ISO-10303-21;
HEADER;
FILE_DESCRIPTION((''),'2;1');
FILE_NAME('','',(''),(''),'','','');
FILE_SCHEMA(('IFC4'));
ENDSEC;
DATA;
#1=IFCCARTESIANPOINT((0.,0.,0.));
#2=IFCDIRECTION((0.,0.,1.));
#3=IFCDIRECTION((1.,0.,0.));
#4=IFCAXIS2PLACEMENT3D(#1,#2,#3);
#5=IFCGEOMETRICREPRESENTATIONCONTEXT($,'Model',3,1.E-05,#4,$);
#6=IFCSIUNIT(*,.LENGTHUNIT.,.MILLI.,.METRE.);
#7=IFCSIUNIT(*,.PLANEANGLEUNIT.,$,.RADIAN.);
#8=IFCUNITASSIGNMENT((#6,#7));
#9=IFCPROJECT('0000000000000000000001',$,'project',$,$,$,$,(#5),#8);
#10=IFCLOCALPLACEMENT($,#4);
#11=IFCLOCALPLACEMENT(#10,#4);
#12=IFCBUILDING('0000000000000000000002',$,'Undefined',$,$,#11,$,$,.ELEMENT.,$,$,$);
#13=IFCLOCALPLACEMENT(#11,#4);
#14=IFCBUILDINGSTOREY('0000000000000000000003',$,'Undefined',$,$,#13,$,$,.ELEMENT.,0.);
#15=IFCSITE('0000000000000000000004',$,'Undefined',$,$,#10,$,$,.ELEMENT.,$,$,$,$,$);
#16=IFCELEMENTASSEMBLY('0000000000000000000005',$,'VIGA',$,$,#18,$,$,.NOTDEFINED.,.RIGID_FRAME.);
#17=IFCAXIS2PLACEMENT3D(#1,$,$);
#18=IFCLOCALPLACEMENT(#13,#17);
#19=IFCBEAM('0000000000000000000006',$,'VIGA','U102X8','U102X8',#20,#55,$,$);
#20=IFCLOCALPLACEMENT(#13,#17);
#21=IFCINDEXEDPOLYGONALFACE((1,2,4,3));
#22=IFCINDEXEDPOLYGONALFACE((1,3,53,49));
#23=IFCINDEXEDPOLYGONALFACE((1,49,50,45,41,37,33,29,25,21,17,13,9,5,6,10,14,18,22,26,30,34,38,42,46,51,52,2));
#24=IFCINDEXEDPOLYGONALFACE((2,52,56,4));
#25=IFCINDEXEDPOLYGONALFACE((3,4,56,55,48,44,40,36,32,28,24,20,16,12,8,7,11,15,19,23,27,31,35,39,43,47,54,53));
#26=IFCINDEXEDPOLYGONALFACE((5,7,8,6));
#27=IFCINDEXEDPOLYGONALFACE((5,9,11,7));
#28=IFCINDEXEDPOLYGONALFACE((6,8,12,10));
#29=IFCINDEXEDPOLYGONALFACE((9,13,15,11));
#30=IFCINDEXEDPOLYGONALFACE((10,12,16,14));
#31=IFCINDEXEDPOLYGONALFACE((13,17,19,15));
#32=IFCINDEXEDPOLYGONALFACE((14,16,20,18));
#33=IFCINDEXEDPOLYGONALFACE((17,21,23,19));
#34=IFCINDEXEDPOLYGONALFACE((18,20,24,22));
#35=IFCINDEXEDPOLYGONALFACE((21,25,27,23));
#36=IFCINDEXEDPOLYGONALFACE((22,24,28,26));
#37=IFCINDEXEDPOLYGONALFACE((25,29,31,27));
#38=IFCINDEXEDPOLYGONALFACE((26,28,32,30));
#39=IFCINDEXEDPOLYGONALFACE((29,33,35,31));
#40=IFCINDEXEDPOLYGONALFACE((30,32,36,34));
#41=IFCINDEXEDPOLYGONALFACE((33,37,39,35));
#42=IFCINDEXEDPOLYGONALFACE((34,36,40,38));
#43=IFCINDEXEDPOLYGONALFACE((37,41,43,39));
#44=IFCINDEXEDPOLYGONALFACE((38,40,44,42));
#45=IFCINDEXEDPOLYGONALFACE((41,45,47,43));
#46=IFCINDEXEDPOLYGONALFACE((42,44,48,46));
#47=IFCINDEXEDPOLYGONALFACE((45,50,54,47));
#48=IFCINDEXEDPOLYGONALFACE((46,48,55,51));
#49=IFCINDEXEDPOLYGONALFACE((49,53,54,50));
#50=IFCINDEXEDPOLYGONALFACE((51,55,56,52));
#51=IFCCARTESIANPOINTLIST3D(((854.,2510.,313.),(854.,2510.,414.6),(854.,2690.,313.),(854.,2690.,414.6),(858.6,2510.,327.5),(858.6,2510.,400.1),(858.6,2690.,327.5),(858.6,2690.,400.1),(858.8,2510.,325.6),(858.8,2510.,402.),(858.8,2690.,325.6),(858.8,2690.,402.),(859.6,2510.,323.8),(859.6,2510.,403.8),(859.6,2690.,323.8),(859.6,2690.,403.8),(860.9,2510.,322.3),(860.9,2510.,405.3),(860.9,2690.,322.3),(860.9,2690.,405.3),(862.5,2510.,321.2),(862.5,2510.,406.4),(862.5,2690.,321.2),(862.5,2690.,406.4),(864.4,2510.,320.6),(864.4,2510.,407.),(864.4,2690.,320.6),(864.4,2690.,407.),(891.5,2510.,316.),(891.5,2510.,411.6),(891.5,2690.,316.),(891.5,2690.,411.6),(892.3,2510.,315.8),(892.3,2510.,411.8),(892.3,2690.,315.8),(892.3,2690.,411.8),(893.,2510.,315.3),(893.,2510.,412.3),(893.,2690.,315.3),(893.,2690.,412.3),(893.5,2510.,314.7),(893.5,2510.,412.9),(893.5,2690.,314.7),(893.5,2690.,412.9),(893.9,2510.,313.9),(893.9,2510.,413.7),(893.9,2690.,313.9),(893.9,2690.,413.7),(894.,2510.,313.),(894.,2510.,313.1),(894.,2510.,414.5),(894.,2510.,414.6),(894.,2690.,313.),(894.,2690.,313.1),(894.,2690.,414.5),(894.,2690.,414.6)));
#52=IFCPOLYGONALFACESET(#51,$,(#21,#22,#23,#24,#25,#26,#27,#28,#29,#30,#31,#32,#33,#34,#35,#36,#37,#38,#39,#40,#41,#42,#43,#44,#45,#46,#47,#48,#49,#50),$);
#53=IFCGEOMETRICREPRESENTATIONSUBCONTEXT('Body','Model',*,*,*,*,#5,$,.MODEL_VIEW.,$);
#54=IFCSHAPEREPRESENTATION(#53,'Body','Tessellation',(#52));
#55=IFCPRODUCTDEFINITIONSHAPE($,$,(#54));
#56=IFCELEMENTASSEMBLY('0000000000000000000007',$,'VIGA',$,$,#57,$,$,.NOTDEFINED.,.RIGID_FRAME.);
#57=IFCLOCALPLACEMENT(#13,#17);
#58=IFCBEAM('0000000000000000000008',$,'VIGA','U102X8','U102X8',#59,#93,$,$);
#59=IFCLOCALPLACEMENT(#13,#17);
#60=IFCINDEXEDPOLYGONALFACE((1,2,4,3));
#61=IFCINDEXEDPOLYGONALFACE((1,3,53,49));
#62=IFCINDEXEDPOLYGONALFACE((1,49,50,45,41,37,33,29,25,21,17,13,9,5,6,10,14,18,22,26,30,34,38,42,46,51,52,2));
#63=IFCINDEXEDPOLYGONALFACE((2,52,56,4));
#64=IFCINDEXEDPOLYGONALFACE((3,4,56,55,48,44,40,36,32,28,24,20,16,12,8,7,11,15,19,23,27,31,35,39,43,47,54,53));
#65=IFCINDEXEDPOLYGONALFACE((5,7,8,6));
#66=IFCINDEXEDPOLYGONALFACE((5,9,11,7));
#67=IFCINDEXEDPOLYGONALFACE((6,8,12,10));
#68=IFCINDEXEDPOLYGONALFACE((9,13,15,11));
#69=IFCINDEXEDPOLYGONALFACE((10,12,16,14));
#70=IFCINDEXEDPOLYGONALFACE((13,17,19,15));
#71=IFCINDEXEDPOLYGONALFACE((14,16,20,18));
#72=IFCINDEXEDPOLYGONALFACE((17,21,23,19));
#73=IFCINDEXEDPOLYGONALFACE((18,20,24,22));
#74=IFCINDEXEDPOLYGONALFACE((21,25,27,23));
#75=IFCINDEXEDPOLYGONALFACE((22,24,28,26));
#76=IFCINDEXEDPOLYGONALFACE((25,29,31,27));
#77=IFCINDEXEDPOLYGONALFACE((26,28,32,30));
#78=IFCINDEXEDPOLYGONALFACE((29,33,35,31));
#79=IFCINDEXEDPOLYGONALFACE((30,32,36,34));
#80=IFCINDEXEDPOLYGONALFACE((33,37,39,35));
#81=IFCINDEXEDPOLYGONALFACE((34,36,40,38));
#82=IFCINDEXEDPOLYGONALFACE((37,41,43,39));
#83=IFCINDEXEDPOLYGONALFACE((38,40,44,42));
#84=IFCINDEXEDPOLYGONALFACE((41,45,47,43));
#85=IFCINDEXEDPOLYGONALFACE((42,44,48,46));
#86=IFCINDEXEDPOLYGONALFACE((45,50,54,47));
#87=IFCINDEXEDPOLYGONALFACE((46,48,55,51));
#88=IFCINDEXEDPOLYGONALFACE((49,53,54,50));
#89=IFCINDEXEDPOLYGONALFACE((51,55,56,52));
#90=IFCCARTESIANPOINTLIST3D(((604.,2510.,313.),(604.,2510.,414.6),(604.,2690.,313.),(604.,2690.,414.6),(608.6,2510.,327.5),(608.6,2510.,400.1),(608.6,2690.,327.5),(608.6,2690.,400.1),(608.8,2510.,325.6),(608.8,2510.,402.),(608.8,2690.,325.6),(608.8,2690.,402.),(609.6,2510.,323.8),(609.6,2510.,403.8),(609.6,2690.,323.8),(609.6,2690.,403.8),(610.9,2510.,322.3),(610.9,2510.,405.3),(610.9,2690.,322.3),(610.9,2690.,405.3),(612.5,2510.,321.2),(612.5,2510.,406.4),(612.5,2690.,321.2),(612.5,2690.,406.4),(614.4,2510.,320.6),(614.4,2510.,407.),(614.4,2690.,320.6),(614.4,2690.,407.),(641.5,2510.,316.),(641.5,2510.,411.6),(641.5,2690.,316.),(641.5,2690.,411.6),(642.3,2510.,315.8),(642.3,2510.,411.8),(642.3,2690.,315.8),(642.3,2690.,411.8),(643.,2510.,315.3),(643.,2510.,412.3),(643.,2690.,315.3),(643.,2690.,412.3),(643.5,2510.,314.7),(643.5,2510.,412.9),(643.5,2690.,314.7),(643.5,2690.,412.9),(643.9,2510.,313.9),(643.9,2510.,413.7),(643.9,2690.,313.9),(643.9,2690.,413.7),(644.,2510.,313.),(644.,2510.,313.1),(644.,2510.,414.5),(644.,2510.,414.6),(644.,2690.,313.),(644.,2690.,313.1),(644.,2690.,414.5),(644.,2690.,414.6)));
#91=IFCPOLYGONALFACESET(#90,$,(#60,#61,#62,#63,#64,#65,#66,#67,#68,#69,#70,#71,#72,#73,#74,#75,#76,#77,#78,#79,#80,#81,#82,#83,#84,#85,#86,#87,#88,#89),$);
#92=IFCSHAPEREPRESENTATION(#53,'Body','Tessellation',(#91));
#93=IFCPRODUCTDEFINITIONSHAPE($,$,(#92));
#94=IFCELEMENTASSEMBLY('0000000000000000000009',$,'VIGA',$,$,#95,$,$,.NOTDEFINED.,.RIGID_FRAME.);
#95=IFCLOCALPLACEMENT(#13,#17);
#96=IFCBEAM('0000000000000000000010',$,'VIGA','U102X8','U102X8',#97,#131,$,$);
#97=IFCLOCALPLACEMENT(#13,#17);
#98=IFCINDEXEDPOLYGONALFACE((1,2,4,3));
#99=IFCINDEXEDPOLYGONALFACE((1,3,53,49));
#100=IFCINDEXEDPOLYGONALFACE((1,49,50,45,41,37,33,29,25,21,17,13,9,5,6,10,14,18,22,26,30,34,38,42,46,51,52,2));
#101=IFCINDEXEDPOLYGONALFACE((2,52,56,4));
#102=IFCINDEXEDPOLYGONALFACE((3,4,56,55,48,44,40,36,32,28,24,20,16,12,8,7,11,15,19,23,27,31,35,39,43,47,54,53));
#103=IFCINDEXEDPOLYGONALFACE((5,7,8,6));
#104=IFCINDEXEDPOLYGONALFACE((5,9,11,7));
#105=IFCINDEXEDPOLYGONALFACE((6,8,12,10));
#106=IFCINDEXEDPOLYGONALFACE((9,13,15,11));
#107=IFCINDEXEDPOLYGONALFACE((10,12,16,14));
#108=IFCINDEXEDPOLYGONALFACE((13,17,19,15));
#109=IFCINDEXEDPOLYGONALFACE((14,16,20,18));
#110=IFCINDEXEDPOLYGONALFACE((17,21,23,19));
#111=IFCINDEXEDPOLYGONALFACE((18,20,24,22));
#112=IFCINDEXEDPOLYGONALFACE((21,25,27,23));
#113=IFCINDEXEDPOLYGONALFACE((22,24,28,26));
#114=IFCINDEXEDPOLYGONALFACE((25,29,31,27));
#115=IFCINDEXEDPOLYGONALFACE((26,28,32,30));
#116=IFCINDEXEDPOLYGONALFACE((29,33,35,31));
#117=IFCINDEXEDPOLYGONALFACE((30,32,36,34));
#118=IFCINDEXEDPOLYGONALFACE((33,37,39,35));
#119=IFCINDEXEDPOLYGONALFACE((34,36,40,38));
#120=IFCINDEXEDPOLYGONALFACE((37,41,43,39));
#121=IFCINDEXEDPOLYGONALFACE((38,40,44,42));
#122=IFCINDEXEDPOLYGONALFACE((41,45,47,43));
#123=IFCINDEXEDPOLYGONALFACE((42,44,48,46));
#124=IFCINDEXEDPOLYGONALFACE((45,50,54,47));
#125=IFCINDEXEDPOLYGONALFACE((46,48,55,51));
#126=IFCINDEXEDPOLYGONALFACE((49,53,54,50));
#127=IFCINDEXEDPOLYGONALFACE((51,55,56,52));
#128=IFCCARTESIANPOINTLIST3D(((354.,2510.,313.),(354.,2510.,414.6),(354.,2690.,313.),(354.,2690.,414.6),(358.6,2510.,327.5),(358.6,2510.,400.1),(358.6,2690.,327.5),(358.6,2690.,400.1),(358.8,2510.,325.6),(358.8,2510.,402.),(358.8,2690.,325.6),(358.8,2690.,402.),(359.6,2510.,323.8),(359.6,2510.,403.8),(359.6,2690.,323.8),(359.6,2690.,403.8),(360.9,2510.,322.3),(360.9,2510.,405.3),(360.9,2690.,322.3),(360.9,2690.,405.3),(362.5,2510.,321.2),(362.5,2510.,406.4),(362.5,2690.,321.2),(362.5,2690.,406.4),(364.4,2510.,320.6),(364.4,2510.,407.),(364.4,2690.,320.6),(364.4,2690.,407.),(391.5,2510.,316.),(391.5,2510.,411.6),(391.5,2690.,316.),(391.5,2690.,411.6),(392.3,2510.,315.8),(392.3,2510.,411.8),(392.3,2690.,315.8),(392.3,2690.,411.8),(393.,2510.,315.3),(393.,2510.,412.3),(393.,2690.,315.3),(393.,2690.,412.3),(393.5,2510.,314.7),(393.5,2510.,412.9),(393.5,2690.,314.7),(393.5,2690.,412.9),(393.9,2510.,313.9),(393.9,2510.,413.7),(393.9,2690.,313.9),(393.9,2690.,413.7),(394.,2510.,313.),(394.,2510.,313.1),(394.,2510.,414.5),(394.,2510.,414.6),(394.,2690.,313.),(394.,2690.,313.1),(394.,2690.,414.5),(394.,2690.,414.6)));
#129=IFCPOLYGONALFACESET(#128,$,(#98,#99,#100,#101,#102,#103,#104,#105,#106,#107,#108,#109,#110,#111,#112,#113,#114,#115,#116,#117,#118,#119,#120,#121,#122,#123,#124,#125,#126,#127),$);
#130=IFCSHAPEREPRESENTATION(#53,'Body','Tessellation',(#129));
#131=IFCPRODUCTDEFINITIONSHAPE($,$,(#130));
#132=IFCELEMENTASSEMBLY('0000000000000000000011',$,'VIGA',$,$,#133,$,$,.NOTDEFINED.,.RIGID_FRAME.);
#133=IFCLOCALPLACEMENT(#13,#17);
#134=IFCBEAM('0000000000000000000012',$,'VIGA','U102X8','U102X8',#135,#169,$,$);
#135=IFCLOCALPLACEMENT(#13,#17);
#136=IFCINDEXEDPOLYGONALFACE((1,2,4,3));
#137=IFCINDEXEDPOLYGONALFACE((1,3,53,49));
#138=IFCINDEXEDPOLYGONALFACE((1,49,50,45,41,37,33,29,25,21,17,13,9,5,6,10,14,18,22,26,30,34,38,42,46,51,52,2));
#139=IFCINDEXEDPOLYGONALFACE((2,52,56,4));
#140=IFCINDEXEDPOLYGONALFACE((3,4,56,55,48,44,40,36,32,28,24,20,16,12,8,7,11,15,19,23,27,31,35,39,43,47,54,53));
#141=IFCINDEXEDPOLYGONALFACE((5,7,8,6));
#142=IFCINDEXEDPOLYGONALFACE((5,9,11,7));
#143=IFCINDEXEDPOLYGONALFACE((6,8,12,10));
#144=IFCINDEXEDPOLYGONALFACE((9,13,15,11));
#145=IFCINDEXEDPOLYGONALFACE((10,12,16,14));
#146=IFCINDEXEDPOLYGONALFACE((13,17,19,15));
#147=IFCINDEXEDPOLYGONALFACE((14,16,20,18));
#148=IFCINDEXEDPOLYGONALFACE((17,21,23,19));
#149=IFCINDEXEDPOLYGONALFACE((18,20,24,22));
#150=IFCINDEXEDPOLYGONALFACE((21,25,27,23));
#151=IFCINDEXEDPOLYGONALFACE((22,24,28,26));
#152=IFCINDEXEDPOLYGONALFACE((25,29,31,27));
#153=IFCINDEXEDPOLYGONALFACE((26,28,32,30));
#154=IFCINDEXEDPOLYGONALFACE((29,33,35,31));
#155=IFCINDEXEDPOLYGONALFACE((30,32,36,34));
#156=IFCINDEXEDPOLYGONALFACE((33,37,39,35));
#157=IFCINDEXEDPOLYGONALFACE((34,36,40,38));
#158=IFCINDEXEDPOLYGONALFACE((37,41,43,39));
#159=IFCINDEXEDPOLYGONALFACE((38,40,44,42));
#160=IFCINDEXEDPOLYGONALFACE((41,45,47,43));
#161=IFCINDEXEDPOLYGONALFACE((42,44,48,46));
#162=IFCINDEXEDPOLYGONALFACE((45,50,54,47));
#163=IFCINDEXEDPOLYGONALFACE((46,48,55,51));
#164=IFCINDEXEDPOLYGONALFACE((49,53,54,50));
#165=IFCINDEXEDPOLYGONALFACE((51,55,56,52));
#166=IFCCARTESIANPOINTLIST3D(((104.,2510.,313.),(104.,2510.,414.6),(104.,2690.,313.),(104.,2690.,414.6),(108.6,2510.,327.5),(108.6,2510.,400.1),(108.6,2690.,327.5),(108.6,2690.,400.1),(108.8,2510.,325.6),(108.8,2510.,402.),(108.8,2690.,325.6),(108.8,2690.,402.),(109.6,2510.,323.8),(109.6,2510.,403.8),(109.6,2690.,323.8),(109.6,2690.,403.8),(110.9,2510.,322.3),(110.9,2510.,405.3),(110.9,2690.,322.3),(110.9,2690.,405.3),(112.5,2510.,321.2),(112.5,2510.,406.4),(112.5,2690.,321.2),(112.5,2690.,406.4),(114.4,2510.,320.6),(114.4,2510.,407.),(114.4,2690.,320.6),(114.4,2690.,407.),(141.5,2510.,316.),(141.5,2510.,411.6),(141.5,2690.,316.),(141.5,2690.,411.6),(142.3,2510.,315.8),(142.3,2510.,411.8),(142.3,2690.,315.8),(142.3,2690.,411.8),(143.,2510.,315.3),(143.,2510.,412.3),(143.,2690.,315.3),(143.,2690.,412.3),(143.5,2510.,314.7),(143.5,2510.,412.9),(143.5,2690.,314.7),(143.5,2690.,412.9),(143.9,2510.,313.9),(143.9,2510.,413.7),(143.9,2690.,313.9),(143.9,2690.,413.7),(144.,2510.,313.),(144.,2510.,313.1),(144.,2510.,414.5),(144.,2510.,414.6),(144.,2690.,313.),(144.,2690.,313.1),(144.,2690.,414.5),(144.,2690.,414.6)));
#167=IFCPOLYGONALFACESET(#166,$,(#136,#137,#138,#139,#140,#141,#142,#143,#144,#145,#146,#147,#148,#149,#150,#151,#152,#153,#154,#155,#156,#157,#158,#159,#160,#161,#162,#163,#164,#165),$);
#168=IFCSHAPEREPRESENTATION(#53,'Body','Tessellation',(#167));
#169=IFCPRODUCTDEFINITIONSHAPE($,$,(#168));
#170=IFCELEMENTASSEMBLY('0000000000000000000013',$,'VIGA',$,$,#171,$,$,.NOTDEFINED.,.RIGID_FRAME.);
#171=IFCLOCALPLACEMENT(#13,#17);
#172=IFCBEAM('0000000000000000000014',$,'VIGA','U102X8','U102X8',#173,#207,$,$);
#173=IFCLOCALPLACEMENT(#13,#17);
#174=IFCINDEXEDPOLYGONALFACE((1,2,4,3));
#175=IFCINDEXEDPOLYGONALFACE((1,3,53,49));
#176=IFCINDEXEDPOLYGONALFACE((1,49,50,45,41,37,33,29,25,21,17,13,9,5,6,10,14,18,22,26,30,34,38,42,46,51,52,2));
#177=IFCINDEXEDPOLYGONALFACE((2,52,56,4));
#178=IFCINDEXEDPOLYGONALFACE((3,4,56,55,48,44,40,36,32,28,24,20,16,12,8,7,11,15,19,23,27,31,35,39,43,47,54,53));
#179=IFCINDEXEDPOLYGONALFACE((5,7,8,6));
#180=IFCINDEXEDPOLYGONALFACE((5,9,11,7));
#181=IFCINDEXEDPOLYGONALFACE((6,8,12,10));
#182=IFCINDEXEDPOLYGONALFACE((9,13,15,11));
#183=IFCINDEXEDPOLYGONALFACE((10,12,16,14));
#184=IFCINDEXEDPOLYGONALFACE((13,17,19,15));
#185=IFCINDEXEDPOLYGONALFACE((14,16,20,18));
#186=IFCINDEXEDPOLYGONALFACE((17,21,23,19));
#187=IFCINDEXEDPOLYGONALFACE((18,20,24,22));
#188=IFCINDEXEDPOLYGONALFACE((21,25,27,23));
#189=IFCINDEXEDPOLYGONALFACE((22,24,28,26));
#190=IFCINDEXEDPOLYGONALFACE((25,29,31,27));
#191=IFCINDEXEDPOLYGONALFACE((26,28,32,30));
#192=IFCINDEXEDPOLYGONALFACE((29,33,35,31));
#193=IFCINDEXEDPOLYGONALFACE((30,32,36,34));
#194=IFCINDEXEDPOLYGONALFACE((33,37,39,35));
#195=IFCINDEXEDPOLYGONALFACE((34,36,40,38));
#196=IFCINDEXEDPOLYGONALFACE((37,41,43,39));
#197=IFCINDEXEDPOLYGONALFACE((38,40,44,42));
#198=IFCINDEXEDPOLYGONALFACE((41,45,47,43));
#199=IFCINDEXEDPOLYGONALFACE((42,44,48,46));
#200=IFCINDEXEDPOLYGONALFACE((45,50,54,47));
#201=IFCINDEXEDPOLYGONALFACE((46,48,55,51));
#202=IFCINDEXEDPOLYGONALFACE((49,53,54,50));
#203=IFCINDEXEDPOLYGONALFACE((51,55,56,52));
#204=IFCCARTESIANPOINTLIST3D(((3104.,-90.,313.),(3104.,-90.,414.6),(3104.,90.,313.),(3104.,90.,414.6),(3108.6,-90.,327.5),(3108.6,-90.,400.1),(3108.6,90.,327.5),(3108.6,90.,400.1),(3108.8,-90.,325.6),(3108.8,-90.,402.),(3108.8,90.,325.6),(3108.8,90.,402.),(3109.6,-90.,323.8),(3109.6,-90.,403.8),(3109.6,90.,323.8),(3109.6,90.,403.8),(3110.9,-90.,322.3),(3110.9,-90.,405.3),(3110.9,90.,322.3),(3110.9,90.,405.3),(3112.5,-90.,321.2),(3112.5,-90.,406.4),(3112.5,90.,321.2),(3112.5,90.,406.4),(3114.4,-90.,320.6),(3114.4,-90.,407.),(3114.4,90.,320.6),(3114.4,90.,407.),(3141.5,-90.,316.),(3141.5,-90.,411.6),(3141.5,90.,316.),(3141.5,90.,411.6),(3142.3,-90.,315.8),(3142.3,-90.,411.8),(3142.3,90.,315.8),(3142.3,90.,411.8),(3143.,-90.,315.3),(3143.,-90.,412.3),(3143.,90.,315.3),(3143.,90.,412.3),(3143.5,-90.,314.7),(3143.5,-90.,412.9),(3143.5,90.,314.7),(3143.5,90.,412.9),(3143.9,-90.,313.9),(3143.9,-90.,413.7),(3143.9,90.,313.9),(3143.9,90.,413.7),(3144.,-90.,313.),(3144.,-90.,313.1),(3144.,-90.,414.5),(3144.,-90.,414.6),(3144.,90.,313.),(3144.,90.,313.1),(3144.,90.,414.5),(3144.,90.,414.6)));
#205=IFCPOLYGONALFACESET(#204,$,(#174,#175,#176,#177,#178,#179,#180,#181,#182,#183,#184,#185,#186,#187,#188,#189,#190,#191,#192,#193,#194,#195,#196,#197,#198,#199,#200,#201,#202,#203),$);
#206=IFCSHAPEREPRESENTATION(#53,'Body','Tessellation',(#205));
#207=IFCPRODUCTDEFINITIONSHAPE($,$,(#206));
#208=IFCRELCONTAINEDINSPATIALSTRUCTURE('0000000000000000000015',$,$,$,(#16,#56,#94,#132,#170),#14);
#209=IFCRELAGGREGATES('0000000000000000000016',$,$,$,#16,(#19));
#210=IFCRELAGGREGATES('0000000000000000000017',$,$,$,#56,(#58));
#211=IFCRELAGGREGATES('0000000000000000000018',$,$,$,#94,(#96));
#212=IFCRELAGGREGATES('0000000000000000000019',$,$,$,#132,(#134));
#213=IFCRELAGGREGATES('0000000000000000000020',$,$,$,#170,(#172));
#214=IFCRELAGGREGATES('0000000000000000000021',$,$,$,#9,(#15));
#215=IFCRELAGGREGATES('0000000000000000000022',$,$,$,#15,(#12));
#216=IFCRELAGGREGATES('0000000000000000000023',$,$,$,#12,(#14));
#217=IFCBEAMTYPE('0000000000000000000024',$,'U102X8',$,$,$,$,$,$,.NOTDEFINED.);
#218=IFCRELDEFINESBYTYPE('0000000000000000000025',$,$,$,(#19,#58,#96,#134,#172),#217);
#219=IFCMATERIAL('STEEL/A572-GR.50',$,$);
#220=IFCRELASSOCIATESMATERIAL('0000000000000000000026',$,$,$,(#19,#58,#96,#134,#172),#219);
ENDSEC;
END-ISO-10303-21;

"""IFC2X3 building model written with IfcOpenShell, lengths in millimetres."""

from ifc_helpers import new_model, si_unit, frame, origin_with_axes, origin_2d_with_axis, place, context, subcontext, project, spatial, u_section, extrude, material, type_object, element, aggregate, save


model = new_model("IFC2X3")

# Units and contexts
model_context = context("Model", 3, precision=1e-05, world=origin_with_axes())
body_context = subcontext(model_context, "Body", "Model", "MODEL_VIEW")
ifc_project = project(units=[si_unit("LENGTHUNIT", "METRE", prefix="MILLI"), si_unit("PLANEANGLEUNIT", "RADIAN")], contexts=[model_context])

# Site, building, storey
site_placement = place(None, origin_with_axes())
site = spatial("IfcSite", under=ifc_project, at=site_placement, Name="Undefined", CompositionType="ELEMENT")
building_placement = place(site_placement, origin_with_axes())
building = spatial("IfcBuilding", under=site, at=building_placement, Name="Undefined", CompositionType="ELEMENT")
storey_placement = place(building_placement, origin_with_axes())
storey = spatial("IfcBuildingStorey", under=building, at=storey_placement, Name="Undefined", CompositionType="ELEMENT", Elevation=0.0)

# Element assemblies, beams
ifc_material_1 = material(Name="STEEL/A572-GR.50")
beam_type_1 = type_object("IfcBeamType", Name="U102X8", PredefinedType="NOTDEFINED")
assembly_1_placement = place(storey_placement, origin_with_axes())
assembly_1 = element("IfcElementAssembly", 1, at=assembly_1_placement, inside=storey, Name="VIGA", AssemblyPlace="NOTDEFINED", PredefinedType="RIGID_FRAME")
beam_1_placement = place(assembly_1_placement, frame((874.0, 2510.0, 363.8), z_axis=(0.0, 0.0, 1.0), x_axis=(0.0, 1.0, 0.0)))
beam_1 = element("IfcBeam", 2, at=beam_1_placement, type_object=beam_type_1, material=ifc_material_1, Name="VIGA", Description="U102X8", ObjectType="U102X8", context=body_context, shape_type="SweptSolid", body=[
    extrude(u_section(Depth=101.6, FlangeWidth=40.0, WebThickness=4.6, FlangeThickness=6.0, FilletRadius=7.0, EdgeRadius=3.0, FlangeSlope=0.16839, at=origin_2d_with_axis()), frame((180.0, 0.0, 0.0), z_axis=(-1.0, 0.0, 0.0), x_axis=(0.0, -1.0, 0.0)), (0.0, 0.0, 1.0), 180.0),
])
aggregate(assembly_1, [beam_1])
assembly_2_placement = place(storey_placement, origin_with_axes())
assembly_2 = element("IfcElementAssembly", 3, at=assembly_2_placement, inside=storey, Name="VIGA", AssemblyPlace="NOTDEFINED", PredefinedType="RIGID_FRAME")
beam_2_placement = place(assembly_2_placement, frame((624.0, 2510.0, 363.8), z_axis=(0.0, 0.0, 1.0), x_axis=(0.0, 1.0, 0.0)))
beam_2 = element("IfcBeam", 4, at=beam_2_placement, type_object=beam_type_1, material=ifc_material_1, Name="VIGA", Description="U102X8", ObjectType="U102X8", context=body_context, shape_type="SweptSolid", body=[
    extrude(u_section(Depth=101.6, FlangeWidth=40.0, WebThickness=4.6, FlangeThickness=6.0, FilletRadius=7.0, EdgeRadius=3.0, FlangeSlope=0.16839, at=origin_2d_with_axis()), frame((180.0, 0.0, 0.0), z_axis=(-1.0, 0.0, 0.0), x_axis=(0.0, -1.0, 0.0)), (0.0, 0.0, 1.0), 180.0),
])
aggregate(assembly_2, [beam_2])
assembly_3_placement = place(storey_placement, origin_with_axes())
assembly_3 = element("IfcElementAssembly", 5, at=assembly_3_placement, inside=storey, Name="VIGA", AssemblyPlace="NOTDEFINED", PredefinedType="RIGID_FRAME")
beam_3_placement = place(assembly_3_placement, frame((374.0, 2510.0, 363.8), z_axis=(0.0, 0.0, 1.0), x_axis=(0.0, 1.0, 0.0)))
beam_3 = element("IfcBeam", 6, at=beam_3_placement, type_object=beam_type_1, material=ifc_material_1, Name="VIGA", Description="U102X8", ObjectType="U102X8", context=body_context, shape_type="SweptSolid", body=[
    extrude(u_section(Depth=101.6, FlangeWidth=40.0, WebThickness=4.6, FlangeThickness=6.0, FilletRadius=7.0, EdgeRadius=3.0, FlangeSlope=0.16839, at=origin_2d_with_axis()), frame((180.0, 0.0, 0.0), z_axis=(-1.0, 0.0, 0.0), x_axis=(0.0, -1.0, 0.0)), (0.0, 0.0, 1.0), 180.0),
])
aggregate(assembly_3, [beam_3])
assembly_4_placement = place(storey_placement, origin_with_axes())
assembly_4 = element("IfcElementAssembly", 7, at=assembly_4_placement, inside=storey, Name="VIGA", AssemblyPlace="NOTDEFINED", PredefinedType="RIGID_FRAME")
beam_4_placement = place(assembly_4_placement, frame((124.0, 2510.0, 363.8), z_axis=(0.0, 0.0, 1.0), x_axis=(0.0, 1.0, 0.0)))
beam_4 = element("IfcBeam", 8, at=beam_4_placement, type_object=beam_type_1, material=ifc_material_1, Name="VIGA", Description="U102X8", ObjectType="U102X8", context=body_context, shape_type="SweptSolid", body=[
    extrude(u_section(Depth=101.6, FlangeWidth=40.0, WebThickness=4.6, FlangeThickness=6.0, FilletRadius=7.0, EdgeRadius=3.0, FlangeSlope=0.16839, at=origin_2d_with_axis()), frame((180.0, 0.0, 0.0), z_axis=(-1.0, 0.0, 0.0), x_axis=(0.0, -1.0, 0.0)), (0.0, 0.0, 1.0), 180.0),
])
aggregate(assembly_4, [beam_4])
assembly_5_placement = place(storey_placement, origin_with_axes())
assembly_5 = element("IfcElementAssembly", 9, at=assembly_5_placement, inside=storey, Name="VIGA", AssemblyPlace="NOTDEFINED", PredefinedType="RIGID_FRAME")
beam_5_placement = place(assembly_5_placement, frame((3124.0, -90.0, 363.8), z_axis=(0.0, 0.0, 1.0), x_axis=(0.0, 1.0, 0.0)))
beam_5 = element("IfcBeam", 10, at=beam_5_placement, type_object=beam_type_1, material=ifc_material_1, Name="VIGA", Description="U102X8", ObjectType="U102X8", context=body_context, shape_type="SweptSolid", body=[
    extrude(u_section(Depth=101.6, FlangeWidth=40.0, WebThickness=4.6, FlangeThickness=6.0, FilletRadius=7.0, EdgeRadius=3.0, FlangeSlope=0.16839, at=origin_2d_with_axis()), frame((180.0, 0.0, 0.0), z_axis=(-1.0, 0.0, 0.0), x_axis=(0.0, -1.0, 0.0)), (0.0, 0.0, 1.0), 180.0),
])
aggregate(assembly_5, [beam_5])

save(model, "model.ifc")
